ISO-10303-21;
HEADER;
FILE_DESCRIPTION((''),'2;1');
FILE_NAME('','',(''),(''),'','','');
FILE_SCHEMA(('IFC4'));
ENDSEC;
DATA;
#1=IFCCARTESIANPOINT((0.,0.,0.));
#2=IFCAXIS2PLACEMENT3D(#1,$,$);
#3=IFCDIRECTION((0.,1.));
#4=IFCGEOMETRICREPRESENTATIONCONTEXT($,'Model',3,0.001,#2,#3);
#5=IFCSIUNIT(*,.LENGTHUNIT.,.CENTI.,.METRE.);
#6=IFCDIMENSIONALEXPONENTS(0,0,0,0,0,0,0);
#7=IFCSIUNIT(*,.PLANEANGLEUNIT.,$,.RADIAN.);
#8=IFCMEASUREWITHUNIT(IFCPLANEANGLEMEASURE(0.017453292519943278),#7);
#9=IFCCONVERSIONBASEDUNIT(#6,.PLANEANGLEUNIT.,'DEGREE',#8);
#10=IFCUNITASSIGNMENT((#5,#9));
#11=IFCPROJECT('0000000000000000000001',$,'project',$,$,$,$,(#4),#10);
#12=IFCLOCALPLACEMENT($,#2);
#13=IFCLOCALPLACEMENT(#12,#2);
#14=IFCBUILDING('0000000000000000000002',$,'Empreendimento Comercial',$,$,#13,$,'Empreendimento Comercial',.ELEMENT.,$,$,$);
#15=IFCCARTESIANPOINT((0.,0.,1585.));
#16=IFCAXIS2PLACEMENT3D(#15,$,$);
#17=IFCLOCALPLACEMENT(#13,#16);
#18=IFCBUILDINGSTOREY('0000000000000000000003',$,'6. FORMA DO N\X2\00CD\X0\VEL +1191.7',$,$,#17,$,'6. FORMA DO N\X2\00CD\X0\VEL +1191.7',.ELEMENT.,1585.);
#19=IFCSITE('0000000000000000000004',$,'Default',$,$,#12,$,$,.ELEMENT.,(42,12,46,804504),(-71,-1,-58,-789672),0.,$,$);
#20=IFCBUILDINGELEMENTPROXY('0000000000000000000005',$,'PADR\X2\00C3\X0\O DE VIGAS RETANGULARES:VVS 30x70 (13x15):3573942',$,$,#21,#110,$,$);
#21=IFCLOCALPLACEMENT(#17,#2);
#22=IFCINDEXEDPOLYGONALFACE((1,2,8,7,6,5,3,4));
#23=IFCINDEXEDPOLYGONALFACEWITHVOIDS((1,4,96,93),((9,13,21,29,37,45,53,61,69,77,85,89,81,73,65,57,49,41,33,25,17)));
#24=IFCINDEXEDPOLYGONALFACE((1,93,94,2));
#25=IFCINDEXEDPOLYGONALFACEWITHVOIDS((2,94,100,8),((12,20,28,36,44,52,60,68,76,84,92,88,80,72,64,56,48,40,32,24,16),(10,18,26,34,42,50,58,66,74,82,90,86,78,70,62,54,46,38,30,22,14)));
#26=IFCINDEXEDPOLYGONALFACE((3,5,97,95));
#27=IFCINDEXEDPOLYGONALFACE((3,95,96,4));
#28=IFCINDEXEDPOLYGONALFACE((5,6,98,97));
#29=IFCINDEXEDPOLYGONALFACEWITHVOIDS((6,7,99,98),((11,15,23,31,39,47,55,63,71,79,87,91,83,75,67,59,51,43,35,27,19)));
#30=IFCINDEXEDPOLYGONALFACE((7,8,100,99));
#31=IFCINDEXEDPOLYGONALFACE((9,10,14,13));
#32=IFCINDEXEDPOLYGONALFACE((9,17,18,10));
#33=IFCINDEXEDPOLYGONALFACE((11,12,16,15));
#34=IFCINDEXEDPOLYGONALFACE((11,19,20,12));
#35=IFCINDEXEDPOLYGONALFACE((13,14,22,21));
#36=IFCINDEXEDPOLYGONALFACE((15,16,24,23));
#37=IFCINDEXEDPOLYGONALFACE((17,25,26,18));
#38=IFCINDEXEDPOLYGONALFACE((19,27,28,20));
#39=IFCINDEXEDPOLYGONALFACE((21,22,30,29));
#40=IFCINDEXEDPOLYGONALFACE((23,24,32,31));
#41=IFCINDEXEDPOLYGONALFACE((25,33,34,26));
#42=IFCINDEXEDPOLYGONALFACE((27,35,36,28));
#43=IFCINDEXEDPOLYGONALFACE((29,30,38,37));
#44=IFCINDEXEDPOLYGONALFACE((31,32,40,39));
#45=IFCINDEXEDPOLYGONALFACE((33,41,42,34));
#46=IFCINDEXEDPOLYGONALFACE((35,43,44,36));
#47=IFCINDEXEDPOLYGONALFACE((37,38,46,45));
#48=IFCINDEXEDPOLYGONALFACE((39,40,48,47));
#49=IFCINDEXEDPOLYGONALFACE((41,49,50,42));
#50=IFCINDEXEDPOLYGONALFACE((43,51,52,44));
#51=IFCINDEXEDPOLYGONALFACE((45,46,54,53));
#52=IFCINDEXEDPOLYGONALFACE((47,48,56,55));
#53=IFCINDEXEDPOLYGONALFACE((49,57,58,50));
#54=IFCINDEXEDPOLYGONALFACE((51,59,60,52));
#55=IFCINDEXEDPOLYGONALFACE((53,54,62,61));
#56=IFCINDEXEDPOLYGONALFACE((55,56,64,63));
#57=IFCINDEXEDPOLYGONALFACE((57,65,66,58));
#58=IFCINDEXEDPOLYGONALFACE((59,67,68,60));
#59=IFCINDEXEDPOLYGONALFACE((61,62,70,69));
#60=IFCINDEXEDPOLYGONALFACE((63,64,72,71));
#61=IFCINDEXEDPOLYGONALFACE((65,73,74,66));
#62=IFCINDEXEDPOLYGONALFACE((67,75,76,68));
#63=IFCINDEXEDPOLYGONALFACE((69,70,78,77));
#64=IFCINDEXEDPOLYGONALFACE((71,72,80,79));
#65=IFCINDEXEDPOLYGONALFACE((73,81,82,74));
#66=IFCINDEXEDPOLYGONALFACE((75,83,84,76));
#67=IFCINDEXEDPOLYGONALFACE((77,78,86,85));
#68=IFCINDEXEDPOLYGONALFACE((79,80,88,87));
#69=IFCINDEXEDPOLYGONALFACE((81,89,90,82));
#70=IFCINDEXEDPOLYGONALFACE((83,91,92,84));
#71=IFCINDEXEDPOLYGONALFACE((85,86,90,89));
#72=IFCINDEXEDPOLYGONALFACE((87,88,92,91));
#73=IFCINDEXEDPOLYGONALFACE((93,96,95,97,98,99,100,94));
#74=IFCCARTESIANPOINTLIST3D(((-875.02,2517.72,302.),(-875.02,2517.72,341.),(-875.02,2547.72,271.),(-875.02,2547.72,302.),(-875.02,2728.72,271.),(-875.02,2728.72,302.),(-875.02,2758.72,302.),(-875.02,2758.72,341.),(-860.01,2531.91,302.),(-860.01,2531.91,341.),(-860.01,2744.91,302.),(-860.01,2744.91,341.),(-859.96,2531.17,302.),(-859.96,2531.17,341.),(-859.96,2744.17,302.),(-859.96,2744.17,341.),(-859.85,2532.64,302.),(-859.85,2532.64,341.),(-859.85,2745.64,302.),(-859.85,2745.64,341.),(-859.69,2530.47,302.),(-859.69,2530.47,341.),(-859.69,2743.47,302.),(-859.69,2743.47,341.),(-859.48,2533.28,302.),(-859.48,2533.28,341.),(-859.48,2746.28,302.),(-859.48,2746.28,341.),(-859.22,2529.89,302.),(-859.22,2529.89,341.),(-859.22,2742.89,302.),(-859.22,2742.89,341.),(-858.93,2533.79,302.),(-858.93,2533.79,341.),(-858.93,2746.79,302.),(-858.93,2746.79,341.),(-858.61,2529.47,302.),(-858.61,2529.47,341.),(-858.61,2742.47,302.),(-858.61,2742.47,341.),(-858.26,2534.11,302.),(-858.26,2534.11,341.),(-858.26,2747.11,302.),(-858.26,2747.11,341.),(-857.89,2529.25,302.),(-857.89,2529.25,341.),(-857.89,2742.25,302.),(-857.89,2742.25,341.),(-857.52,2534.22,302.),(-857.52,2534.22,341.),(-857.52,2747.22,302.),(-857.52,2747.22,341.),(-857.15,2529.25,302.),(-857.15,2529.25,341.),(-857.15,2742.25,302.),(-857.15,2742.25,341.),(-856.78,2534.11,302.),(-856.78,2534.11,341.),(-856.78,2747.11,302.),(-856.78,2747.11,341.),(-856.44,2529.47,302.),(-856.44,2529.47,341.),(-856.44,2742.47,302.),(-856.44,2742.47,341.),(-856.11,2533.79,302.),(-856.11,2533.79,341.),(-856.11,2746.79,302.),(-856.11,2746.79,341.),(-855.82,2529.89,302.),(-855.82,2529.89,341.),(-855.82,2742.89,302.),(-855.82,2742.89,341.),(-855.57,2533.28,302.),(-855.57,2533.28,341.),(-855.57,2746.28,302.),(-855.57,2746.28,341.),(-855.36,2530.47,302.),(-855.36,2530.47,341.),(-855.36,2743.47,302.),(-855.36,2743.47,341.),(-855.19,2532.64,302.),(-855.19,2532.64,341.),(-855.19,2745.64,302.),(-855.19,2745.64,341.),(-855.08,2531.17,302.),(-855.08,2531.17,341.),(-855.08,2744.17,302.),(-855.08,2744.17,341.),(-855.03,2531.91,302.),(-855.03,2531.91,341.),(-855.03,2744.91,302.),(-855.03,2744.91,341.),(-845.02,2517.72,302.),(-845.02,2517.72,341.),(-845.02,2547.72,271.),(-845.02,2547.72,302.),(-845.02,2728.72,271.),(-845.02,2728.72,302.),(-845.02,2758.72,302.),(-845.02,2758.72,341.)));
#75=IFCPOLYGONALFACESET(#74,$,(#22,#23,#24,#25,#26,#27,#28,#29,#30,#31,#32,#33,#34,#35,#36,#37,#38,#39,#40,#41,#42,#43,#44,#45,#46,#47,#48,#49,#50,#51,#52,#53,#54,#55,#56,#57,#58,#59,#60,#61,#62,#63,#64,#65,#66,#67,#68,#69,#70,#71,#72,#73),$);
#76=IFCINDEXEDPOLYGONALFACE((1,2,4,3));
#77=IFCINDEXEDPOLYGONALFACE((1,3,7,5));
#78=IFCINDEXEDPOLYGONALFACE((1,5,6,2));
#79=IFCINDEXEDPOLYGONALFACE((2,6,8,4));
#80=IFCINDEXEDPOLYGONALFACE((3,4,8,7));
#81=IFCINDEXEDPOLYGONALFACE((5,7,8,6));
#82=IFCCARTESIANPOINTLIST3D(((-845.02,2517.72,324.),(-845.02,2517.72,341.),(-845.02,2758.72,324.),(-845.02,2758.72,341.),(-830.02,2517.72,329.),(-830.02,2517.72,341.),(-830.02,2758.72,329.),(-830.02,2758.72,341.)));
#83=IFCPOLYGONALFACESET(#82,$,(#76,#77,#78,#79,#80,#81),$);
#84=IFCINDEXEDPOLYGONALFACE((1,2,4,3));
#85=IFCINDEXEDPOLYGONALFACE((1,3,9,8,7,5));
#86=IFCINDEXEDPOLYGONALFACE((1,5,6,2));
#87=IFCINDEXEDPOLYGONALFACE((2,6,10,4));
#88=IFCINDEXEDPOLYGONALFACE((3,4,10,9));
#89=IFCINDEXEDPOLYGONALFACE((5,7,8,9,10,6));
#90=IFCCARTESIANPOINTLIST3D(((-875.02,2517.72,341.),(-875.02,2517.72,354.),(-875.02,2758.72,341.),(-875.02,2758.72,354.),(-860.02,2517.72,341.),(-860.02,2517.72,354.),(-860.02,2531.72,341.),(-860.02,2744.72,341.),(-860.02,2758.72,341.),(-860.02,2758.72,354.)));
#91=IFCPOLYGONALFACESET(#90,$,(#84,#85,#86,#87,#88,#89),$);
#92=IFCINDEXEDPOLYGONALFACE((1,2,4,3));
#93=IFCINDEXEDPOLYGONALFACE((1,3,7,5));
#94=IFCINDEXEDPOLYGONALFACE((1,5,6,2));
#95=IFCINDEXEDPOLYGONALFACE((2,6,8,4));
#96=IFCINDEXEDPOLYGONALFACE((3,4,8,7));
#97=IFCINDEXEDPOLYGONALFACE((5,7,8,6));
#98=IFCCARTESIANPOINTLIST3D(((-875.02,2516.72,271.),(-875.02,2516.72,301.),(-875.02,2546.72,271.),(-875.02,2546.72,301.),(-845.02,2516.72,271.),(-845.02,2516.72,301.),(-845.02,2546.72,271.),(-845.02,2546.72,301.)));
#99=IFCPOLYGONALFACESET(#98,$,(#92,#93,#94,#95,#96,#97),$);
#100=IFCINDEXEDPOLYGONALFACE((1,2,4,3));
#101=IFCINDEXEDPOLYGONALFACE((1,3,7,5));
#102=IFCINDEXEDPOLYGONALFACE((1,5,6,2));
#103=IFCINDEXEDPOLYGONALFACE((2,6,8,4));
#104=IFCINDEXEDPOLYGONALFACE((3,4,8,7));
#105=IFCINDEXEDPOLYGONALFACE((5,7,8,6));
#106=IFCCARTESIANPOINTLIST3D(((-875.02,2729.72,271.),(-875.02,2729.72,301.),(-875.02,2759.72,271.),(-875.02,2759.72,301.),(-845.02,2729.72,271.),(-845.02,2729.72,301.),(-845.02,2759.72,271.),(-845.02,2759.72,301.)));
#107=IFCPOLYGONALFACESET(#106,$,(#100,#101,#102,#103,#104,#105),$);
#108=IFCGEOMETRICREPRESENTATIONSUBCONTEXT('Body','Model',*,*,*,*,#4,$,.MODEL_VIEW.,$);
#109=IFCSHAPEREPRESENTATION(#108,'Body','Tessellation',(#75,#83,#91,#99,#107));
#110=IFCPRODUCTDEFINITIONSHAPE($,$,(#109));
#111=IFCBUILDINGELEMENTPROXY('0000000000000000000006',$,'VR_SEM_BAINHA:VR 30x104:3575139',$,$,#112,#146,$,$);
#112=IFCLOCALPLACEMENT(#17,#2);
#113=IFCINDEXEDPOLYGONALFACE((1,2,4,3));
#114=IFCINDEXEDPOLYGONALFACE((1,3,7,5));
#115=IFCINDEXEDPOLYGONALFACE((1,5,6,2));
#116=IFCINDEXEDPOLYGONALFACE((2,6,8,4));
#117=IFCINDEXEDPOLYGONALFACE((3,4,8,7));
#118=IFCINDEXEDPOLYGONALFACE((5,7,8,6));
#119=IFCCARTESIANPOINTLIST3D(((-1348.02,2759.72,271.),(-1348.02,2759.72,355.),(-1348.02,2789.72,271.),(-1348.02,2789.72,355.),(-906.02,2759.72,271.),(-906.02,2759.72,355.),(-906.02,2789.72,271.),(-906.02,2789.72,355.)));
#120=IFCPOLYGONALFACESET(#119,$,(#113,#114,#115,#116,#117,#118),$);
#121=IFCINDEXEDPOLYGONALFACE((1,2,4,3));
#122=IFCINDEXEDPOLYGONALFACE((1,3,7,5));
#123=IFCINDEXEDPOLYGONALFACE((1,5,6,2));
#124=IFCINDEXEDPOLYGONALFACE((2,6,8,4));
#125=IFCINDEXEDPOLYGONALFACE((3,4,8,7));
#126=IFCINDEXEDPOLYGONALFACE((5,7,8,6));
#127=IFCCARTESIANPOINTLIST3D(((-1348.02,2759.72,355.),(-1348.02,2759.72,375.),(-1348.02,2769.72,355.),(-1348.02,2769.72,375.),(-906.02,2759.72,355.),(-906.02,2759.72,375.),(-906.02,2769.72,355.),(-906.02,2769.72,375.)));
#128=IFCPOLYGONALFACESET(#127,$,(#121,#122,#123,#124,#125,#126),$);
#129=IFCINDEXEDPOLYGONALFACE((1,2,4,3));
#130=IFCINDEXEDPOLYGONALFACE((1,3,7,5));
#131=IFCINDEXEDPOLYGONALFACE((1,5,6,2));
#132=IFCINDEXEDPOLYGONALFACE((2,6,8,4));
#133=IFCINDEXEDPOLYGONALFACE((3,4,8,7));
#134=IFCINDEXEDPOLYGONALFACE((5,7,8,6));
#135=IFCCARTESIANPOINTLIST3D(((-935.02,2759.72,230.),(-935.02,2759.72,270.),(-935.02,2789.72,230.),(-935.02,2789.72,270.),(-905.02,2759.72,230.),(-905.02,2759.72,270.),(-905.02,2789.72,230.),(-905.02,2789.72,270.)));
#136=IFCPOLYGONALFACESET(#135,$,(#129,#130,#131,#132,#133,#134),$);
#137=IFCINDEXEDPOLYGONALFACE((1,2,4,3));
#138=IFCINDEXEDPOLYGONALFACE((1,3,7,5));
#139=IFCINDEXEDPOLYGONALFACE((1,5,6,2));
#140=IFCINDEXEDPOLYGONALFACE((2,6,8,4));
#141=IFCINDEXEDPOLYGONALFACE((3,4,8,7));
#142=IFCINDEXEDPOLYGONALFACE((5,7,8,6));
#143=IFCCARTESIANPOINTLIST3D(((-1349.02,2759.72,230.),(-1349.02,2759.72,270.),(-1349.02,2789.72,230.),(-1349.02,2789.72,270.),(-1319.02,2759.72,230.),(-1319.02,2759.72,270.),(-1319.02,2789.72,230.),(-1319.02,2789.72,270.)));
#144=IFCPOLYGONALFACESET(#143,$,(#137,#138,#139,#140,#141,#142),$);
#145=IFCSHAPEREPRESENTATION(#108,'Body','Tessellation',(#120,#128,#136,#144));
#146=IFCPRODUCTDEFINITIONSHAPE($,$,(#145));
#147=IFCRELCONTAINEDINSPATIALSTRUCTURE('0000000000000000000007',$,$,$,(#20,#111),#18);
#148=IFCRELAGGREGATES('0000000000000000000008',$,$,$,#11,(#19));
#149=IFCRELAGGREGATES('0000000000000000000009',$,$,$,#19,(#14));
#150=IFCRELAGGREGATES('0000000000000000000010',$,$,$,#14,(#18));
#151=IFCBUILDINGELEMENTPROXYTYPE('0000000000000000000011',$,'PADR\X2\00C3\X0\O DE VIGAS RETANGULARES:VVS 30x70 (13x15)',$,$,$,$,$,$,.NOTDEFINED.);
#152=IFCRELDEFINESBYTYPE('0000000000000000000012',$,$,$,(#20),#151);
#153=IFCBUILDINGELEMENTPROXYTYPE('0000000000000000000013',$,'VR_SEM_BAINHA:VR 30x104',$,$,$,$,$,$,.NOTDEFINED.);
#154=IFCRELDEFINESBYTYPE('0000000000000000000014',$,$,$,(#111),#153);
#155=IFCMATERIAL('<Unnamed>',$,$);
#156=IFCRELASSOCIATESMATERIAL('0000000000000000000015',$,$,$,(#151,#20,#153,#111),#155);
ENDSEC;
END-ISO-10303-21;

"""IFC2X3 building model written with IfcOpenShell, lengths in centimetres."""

from ifc_helpers import new_model, entity, si_unit, converted_unit, direction, frame, frame_2d, origin, origin_2d_with_axis, place, context, subcontext, project, spatial, polyline, rectangle, circle, outline, extrude, source, transform, mapped, material, type_object, type_shapes, element, save


model = new_model("IFC2X3")

# Units and contexts
model_context = context("Model", 3, precision=0.001, world=origin(), true_north=direction((0.0, 1.0)))
body_context = subcontext(model_context, "Body", "Model", "MODEL_VIEW")
ifc_project = project(units=[si_unit("LENGTHUNIT", "METRE", prefix="CENTI"), converted_unit("PLANEANGLEUNIT", "DEGREE", entity("IfcPlaneAngleMeasure", 0.017453292519943278), si_unit("PLANEANGLEUNIT", "RADIAN"), dimensions=[0, 0, 0, 0, 0, 0, 0])], contexts=[model_context])

# Site, building, storey
site_placement = place(None, origin())
site = spatial("IfcSite", under=ifc_project, at=site_placement, Name="Default", CompositionType="ELEMENT", RefLatitude=(42, 12, 46, 804504), RefLongitude=(-71, -1, -58, -789672), RefElevation=0.0)
building_placement = place(site_placement, origin())
building = spatial("IfcBuilding", under=site, at=building_placement, Name="Empreendimento Comercial", LongName="Empreendimento Comercial", CompositionType="ELEMENT")
storey_placement = place(building_placement, frame((0.0, 0.0, 1585.0)))
storey = spatial("IfcBuildingStorey", under=building, at=storey_placement, Name="6. FORMA DO NÍVEL +1191.7", LongName="6. FORMA DO NÍVEL +1191.7", CompositionType="ELEMENT", Elevation=1585.0)

# Building element proxy, openings
ifc_material = material(Name="<Unnamed>")
building_element_proxy_type_1 = type_object("IfcBuildingElementProxyType", Name="PADRÃO DE VIGAS RETANGULARES:VVS 30x70 (13x15)", PredefinedType="NOTDEFINED", material=ifc_material)
shared_shape_1 = source(origin(), body_context, "Body", "SweptSolid", [
    extrude(outline(polyline([(-37.0, -120.5), (2.0, -120.5), (2.0, -90.5), (33.0, -90.5), (33.0, 90.5), (2.0, 90.5), (2.0, 120.5), (-37.0, 120.5), (-37.0, -120.5)])), frame((-875.02, 2638.22, 1889.0), z_axis=(1.0, 0.0, 0.0), x_axis=(0.0, 0.0, -1.0)), (0.0, 0.0, 1.0), 30.0),
    extrude(outline(polyline([(-7.25, -7.5), (4.75, -7.5), (9.75, 7.5), (-7.25, 7.5), (-7.25, -7.5)])), frame((-837.52, 2517.72, 1918.75), z_axis=(0.0, 1.0, 0.0), x_axis=(0.0, 0.0, -1.0)), (0.0, 0.0, 1.0), 241.0),
    extrude(rectangle(XDim=241.0, YDim=15.0, at=origin_2d_with_axis()), frame((-867.52, 2638.22, 1926.0), z_axis=(0.0, 0.0, 1.0), x_axis=(0.0, -1.0, 0.0)), (0.0, 0.0, 1.0), 13.0),
    extrude(rectangle(XDim=30.0, YDim=30.0, at=frame_2d((0.0, 0.0), x_axis=(1.0, 0.0))), frame((-860.02, 2531.72, 1856.0), z_axis=(0.0, 0.0, 1.0), x_axis=(-1.0, 0.0, 0.0)), (0.0, 0.0, 1.0), 30.0),
    extrude(rectangle(XDim=30.0, YDim=30.0, at=frame_2d((0.0, 0.0), x_axis=(1.0, 0.0))), frame((-860.02, 2744.72, 1856.0), z_axis=(0.0, 0.0, 1.0), x_axis=(-1.0, 0.0, 0.0)), (0.0, 0.0, 1.0), 30.0),
])
type_shapes(building_element_proxy_type_1, [shared_shape_1])
proxy_1_placement = place(storey_placement, frame((0.0, 0.0, -1585.0)))
proxy_1 = element("IfcBuildingElementProxy", 1, at=proxy_1_placement, inside=storey, type_object=building_element_proxy_type_1, material=ifc_material, Name="PADRÃO DE VIGAS RETANGULARES:VVS 30x70 (13x15):3573942", context=body_context, shape_type="MappedRepresentation", body=[
    mapped(shared_shape_1, transform((0.0, 0.0, 0.0), scale=1.0)),
])
opening_1_placement = place(storey_placement, frame((0.0, 0.0, -1585.0)))
element("IfcOpeningElement", 2, at=opening_1_placement, cuts=proxy_1, ObjectType="Opening", context=body_context, shape_type="SweptSolid", body=[
    extrude(circle(Radius=2.5, at=origin_2d_with_axis()), frame((-857.52, 2744.72, 1887.0), z_axis=(0.0, 0.0, 1.0), x_axis=(0.0, 1.0, 0.0)), (0.0, 0.0, 1.0), 39.0),
])
opening_2_placement = place(storey_placement, frame((0.0, 0.0, -1585.0)))
element("IfcOpeningElement", 3, at=opening_2_placement, cuts=proxy_1, ObjectType="Opening", context=body_context, shape_type="SweptSolid", body=[
    extrude(circle(Radius=2.5, at=origin_2d_with_axis()), frame((-857.52, 2531.72, 1887.0), z_axis=(0.0, 0.0, 1.0), x_axis=(0.0, 1.0, 0.0)), (0.0, 0.0, 1.0), 39.0),
])

# Building element proxy
building_element_proxy_type_2 = type_object("IfcBuildingElementProxyType", Name="VR_SEM_BAINHA:VR 30x104", PredefinedType="NOTDEFINED", material=ifc_material)
shared_shape_2 = source(origin(), body_context, "Body", "SweptSolid", [
    extrude(rectangle(XDim=442.0, YDim=30.0, at=frame_2d((0.0, 0.0), x_axis=(1.0, 0.0))), frame((-1127.02, 2774.72, 1856.0)), (0.0, 0.0, 1.0), 84.0),
    extrude(rectangle(XDim=442.0, YDim=10.0, at=frame_2d((0.0, 0.0), x_axis=(1.0, 0.0))), frame((-1127.02, 2764.72, 1940.0)), (0.0, 0.0, 1.0), 20.0),
    extrude(rectangle(XDim=30.0, YDim=30.0, at=origin_2d_with_axis()), frame((-920.02, 2774.72, 1815.0), z_axis=(0.0, 0.0, 1.0), x_axis=(0.0, -1.0, 0.0)), (0.0, 0.0, 1.0), 40.0),
    extrude(rectangle(XDim=30.0, YDim=30.0, at=frame_2d((0.0, 0.0), x_axis=(1.0, 0.0))), frame((-1334.02, 2774.72, 1815.0), z_axis=(0.0, 0.0, 1.0), x_axis=(0.0, -1.0, 0.0)), (0.0, 0.0, 1.0), 40.0),
])
type_shapes(building_element_proxy_type_2, [shared_shape_2])
proxy_2_placement = place(storey_placement, frame((0.0, 0.0, -1585.0)))
element("IfcBuildingElementProxy", 4, at=proxy_2_placement, inside=storey, type_object=building_element_proxy_type_2, material=ifc_material, Name="VR_SEM_BAINHA:VR 30x104:3575139", context=body_context, shape_type="MappedRepresentation", body=[
    mapped(shared_shape_2, transform((0.0, 0.0, 0.0), scale=1.0)),
])

save(model, "model.ifc")
